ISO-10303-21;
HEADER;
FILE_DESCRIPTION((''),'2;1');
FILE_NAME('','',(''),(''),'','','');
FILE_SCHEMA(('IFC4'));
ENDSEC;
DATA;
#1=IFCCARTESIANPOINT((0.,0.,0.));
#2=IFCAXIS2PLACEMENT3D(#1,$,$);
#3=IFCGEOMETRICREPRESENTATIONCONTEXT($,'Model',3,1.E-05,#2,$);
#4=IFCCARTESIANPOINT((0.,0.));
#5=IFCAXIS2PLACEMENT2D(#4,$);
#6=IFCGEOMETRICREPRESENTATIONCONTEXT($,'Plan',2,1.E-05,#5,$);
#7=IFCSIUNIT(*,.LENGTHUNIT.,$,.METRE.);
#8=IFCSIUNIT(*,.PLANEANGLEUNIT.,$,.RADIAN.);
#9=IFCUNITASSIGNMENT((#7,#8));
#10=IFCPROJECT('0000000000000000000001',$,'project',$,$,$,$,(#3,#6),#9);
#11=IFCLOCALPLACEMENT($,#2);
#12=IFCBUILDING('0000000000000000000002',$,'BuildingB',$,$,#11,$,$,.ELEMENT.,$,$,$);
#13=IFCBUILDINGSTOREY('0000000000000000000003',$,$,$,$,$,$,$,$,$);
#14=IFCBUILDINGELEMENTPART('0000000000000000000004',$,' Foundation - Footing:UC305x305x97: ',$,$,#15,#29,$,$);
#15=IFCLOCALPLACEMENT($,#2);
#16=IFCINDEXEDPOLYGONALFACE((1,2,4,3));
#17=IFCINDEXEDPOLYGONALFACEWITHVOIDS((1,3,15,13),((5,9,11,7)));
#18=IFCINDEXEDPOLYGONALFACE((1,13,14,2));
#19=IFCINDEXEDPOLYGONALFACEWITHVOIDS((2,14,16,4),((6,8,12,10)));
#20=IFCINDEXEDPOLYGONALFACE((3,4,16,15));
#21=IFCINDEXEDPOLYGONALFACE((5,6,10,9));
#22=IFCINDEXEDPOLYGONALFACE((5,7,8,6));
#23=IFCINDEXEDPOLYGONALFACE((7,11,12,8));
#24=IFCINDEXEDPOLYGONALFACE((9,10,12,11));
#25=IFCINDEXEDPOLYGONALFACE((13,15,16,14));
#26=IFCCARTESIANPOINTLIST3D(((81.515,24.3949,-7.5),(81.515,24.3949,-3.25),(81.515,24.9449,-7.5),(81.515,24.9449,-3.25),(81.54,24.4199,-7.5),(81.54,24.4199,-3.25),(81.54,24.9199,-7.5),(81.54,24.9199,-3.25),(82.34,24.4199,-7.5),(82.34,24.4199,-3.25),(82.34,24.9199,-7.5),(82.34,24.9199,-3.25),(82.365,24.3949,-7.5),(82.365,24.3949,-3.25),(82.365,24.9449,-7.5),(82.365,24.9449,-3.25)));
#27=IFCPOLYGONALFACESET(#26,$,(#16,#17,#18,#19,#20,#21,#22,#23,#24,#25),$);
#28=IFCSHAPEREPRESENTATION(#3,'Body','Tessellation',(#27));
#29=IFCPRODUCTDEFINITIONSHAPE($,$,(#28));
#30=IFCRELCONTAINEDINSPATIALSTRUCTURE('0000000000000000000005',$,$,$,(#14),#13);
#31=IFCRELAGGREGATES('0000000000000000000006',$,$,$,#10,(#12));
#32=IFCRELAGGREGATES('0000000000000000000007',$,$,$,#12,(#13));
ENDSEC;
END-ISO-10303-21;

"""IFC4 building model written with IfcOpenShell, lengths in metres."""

from ifc_helpers import new_model, si_unit, origin, origin_2d, place, context, project, spatial, polyline, outline, extrude, element, save


model = new_model("IFC4")

# Units and contexts
model_context = context("Model", 3, precision=1e-05, world=origin())
plan_context = context("Plan", 2, precision=1e-05, world=origin_2d())
ifc_project = project(units=[si_unit("LENGTHUNIT", "METRE"), si_unit("PLANEANGLEUNIT", "RADIAN")], contexts=[model_context, plan_context])

# Building, storey
building_placement = place(None, origin())
building = spatial("IfcBuilding", under=ifc_project, at=building_placement, Name="BuildingB", CompositionType="ELEMENT")
storey = spatial("IfcBuildingStorey", under=building)

# Building element part, opening
building_element_part_1 = element("IfcBuildingElementPart", 1, inside=storey, Name=" Foundation - Footing:UC305x305x97: ", context=model_context, shape_type="SweptSolid", body=[
    extrude(outline(polyline([(81.515, 24.3949, -7.5), (82.365, 24.3949, -7.5), (82.365, 24.9449, -7.5), (81.515, 24.9449, -7.5), (81.515, 24.3949, -7.5)])), None, (0.0, 0.0, 1.0), 4.25),
])
element("IfcOpeningElement", 2, inside=storey, cuts=building_element_part_1, context=model_context, shape_type="SweptSolid", body=[
    extrude(outline(polyline([(81.54, 24.4199, -7.5), (82.34, 24.4199, -7.5), (82.34, 24.9199, -7.5), (81.54, 24.9199, -7.5), (81.54, 24.4199, -7.5)])), None, (0.0, 0.0, 1.0), 4.25),
])

save(model, "model.ifc")
